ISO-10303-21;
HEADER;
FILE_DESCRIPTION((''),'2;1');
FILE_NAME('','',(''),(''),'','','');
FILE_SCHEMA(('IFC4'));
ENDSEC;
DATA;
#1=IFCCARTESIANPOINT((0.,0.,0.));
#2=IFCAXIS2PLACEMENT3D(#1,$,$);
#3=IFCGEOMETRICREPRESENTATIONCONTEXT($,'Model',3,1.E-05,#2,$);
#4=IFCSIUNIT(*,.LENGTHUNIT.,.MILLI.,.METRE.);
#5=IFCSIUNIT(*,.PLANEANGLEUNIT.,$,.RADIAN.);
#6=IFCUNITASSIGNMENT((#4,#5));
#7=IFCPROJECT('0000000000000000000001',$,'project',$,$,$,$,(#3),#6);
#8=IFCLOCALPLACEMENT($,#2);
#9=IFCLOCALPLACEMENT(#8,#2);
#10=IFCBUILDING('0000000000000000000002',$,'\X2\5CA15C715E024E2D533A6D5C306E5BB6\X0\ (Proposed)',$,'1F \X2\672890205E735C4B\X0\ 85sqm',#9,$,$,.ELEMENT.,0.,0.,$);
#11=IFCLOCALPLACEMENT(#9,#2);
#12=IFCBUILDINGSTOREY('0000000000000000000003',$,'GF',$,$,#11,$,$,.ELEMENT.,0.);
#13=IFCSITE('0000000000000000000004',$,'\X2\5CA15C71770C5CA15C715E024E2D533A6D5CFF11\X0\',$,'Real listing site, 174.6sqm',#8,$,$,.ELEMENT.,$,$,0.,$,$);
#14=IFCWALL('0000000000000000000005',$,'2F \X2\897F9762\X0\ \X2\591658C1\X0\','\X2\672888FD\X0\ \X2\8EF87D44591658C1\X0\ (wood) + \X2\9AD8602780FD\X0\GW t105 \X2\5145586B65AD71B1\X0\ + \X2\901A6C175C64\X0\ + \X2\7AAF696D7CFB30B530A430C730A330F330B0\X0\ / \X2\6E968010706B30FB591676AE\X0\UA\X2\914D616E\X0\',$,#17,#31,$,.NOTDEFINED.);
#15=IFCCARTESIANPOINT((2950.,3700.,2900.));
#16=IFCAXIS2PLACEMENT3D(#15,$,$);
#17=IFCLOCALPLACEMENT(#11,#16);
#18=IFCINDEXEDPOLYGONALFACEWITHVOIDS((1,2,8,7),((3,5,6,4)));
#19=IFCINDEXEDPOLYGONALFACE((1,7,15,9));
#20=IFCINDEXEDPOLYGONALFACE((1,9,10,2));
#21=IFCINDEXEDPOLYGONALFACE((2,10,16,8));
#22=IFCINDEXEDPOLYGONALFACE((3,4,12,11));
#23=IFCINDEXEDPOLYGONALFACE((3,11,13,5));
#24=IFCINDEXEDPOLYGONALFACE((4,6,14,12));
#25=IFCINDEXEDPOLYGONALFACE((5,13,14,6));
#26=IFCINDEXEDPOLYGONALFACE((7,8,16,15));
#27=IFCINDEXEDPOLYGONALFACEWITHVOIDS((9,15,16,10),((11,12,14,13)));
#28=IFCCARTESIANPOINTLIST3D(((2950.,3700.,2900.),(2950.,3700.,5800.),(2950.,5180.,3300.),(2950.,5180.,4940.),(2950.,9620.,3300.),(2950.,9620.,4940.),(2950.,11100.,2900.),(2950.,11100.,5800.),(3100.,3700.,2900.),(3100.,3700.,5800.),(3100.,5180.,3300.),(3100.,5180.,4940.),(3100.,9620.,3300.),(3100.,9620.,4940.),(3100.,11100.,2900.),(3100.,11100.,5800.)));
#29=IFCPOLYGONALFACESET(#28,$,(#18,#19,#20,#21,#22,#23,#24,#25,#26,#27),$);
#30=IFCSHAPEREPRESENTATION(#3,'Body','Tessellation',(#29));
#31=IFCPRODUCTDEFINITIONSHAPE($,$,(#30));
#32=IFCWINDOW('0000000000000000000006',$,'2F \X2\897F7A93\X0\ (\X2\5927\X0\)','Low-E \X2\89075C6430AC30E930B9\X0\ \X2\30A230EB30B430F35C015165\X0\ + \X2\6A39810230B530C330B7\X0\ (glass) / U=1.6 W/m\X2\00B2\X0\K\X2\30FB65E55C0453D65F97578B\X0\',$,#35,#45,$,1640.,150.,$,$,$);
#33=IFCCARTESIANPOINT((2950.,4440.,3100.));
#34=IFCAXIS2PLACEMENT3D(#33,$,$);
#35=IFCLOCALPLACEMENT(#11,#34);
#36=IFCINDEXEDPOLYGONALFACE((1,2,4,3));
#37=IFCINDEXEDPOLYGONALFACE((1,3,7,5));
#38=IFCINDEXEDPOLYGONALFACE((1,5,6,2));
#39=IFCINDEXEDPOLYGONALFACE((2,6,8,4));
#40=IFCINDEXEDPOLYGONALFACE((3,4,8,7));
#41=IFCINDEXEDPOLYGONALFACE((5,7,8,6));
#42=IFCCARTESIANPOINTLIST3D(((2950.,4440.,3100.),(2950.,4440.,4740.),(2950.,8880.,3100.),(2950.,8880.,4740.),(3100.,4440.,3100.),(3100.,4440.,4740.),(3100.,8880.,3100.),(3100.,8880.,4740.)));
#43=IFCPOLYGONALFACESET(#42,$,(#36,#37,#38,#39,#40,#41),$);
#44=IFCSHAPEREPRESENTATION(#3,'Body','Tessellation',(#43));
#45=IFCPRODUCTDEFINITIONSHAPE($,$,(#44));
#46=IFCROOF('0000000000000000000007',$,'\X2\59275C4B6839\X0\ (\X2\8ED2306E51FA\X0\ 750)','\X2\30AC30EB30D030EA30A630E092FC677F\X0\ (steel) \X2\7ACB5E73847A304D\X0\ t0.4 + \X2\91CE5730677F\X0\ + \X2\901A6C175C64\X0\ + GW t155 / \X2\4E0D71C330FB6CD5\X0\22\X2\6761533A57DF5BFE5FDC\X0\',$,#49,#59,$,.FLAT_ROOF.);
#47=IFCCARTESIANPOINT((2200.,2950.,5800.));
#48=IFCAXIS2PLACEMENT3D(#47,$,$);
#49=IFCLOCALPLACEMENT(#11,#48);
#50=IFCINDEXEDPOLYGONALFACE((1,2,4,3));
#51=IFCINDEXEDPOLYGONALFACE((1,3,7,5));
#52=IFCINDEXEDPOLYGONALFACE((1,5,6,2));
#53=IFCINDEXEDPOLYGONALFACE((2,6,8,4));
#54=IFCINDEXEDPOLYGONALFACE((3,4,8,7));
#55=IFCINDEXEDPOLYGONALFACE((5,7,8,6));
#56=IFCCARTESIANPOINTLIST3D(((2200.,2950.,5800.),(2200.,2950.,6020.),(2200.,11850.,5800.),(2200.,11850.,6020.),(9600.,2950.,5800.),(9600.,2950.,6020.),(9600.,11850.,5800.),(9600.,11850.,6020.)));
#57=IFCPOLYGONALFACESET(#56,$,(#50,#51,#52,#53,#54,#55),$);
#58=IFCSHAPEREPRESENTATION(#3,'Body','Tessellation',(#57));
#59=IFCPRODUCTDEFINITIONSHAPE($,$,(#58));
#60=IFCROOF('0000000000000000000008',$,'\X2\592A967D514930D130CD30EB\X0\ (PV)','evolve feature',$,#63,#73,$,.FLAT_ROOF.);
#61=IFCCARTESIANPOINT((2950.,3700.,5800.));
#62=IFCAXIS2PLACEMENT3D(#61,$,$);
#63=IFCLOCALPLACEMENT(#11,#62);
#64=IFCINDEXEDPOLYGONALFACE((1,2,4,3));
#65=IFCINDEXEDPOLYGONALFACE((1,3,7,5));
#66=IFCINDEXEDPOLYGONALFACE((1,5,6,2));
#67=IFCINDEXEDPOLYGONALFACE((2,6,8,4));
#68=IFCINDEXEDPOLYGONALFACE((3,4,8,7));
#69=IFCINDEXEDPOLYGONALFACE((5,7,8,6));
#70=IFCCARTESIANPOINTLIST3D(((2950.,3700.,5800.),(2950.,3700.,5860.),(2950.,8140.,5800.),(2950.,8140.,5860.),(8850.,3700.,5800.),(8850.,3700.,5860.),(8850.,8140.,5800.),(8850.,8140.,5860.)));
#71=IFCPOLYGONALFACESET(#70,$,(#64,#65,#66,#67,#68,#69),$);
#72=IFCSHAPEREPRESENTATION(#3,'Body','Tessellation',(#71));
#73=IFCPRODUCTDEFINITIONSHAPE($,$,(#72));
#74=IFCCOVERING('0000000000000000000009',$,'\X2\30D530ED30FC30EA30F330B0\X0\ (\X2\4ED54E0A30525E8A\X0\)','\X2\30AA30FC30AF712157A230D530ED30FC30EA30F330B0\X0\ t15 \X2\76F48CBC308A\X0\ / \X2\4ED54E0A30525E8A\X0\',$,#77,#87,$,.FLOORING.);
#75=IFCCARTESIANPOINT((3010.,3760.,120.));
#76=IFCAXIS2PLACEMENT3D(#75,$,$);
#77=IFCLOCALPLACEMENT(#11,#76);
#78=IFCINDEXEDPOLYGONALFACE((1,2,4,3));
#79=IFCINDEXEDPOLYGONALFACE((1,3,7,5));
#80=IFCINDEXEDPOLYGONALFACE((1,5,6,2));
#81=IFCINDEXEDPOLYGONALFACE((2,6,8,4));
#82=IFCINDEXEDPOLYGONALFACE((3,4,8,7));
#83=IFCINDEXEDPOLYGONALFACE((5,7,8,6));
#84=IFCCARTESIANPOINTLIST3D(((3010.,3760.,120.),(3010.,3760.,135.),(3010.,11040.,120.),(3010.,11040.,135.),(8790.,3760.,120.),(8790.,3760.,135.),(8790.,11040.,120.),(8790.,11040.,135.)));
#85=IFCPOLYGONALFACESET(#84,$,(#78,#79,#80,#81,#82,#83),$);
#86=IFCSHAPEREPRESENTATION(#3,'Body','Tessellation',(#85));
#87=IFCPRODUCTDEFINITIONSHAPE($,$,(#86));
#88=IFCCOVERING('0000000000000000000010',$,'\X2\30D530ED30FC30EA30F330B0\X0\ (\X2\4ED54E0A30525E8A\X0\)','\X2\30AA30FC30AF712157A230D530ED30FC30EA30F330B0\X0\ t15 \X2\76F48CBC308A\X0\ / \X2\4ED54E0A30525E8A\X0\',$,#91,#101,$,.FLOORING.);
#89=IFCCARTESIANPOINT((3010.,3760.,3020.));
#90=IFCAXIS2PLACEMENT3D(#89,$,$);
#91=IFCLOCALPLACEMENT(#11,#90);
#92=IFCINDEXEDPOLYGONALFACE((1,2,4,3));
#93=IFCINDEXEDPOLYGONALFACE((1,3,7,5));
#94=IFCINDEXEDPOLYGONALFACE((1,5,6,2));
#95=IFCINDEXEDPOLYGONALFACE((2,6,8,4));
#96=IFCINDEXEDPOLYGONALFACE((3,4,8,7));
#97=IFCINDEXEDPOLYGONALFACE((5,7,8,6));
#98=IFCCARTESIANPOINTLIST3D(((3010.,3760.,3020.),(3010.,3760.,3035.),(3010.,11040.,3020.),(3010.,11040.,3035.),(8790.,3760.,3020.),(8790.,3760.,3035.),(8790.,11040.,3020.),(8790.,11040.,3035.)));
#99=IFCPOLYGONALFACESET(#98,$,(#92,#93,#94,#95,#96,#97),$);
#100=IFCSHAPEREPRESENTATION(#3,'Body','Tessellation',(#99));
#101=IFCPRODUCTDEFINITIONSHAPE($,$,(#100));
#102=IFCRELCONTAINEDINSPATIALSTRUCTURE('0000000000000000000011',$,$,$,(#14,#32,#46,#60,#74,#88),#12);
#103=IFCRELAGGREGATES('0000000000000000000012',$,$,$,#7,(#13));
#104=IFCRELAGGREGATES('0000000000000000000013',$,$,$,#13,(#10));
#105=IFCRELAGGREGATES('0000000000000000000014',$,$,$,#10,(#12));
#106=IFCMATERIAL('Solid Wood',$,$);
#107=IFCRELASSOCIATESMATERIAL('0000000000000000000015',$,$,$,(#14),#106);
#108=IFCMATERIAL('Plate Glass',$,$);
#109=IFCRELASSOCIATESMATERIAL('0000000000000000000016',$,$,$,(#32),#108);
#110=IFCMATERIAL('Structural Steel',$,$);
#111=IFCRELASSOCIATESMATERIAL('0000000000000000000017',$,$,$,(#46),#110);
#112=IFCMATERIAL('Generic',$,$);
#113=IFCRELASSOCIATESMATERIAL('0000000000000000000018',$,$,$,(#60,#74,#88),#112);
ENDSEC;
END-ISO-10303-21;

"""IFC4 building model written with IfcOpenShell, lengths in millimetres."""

from ifc_helpers import new_model, si_unit, frame, frame_2d, origin, place, context, project, spatial, rectangle, extrude, material, element, fill, save


model = new_model("IFC4")

# Units and contexts
model_context = context("Model", 3, precision=1e-05, world=origin())
ifc_project = project(units=[si_unit("LENGTHUNIT", "METRE", prefix="MILLI"), si_unit("PLANEANGLEUNIT", "RADIAN")], contexts=[model_context])

# Site, building, storey
site_placement = place(None, origin())
site = spatial("IfcSite", under=ifc_project, at=site_placement, Name="岡山県岡山市中区浜１", ObjectType="Real listing site, 174.6sqm", CompositionType="ELEMENT", RefElevation=0.0)
building_placement = place(site_placement, origin())
building = spatial("IfcBuilding", under=site, at=building_placement, Name="岡山市中区浜の家 (Proposed)", ObjectType="1F 木造平屋 85sqm", CompositionType="ELEMENT", ElevationOfRefHeight=0.0, ElevationOfTerrain=0.0)
storey_placement = place(building_placement, origin())
storey = spatial("IfcBuildingStorey", under=building, at=storey_placement, Name="GF", CompositionType="ELEMENT", Elevation=0.0)

# Shared definitions
ifc_material_1 = material(Name="Solid Wood")
ifc_material_2 = material(Name="Generic")

# Shared definitions
ifc_material_3 = material(Name="Plate Glass")

# Wall, opening, window
wall_1_placement = place(storey_placement, frame((2950.0, 3700.0, 2900.0)))
wall_1 = element("IfcWall", 1, at=wall_1_placement, inside=storey, material=ifc_material_1, Name="2F 西面 外壁", Description="木製 軸組外壁 (wood) + 高性能GW t105 充填断熱 + 通気層 + 窯業系サイディング / 準耐火・外皮UA配慮", PredefinedType="NOTDEFINED", context=model_context, shape_type="SweptSolid", body=[
    extrude(rectangle(XDim=150.0, YDim=7400.0, at=frame_2d((75.0, 3700.0))), frame((2950.0, 3700.0, 2900.0)), (0.0, 0.0, 1.0), 2900.0),
])
opening_1_placement = place(storey_placement, frame((2950.0, 4440.0, 3100.0)))
opening_1 = element("IfcOpeningElement", 2, at=opening_1_placement, cuts=wall_1, PredefinedType="NOTDEFINED", context=model_context, shape_type="SweptSolid", body=[
    extrude(rectangle(XDim=150.0, YDim=4440.0, at=frame_2d((75.0, 2220.0))), frame((2950.0, 4440.0, 3100.0)), (0.0, 0.0, 1.0), 1640.0),
])
window_1_placement = place(storey_placement, frame((2950.0, 4440.0, 3100.0)))
window_1 = element("IfcWindow", 3, at=window_1_placement, inside=storey, material=ifc_material_3, Name="2F 西窓 (大)", Description="Low-E 複層ガラス アルゴン封入 + 樹脂サッシ (glass) / U=1.6 W/m²K・日射取得型", OverallHeight=1640.0, OverallWidth=150.0, context=model_context, shape_type="SweptSolid", body=[
    extrude(rectangle(XDim=150.0, YDim=4440.0, at=frame_2d((75.0, 2220.0))), frame((2950.0, 4440.0, 3100.0)), (0.0, 0.0, 1.0), 1640.0),
])
fill(opening_1, window_1)

# Roofs
ifc_material_4 = material(Name="Structural Steel")
roof_1_placement = place(storey_placement, frame((2200.0, 2950.0, 5800.0)))
element("IfcRoof", 4, at=roof_1_placement, inside=storey, material=ifc_material_4, Name="大屋根 (軒の出 750)", Description="ガルバリウム鋼板 (steel) 立平葺き t0.4 + 野地板 + 通気層 + GW t155 / 不燃・法22条区域対応", PredefinedType="FLAT_ROOF", context=model_context, shape_type="SweptSolid", body=[
    extrude(rectangle(XDim=7400.0, YDim=8900.0, at=frame_2d((3700.0, 4450.0))), frame((2200.0, 2950.0, 5800.0)), (0.0, 0.0, 1.0), 220.0),
])
roof_2_placement = place(storey_placement, frame((2950.0, 3700.0, 5800.0)))
element("IfcRoof", 5, at=roof_2_placement, inside=storey, material=ifc_material_2, Name="太陽光パネル (PV)", Description="evolve feature", PredefinedType="FLAT_ROOF", context=model_context, shape_type="SweptSolid", body=[
    extrude(rectangle(XDim=5900.0, YDim=4440.0, at=frame_2d((2950.0, 2220.0))), frame((2950.0, 3700.0, 5800.0)), (0.0, 0.0, 1.0), 60.0),
])

# Coverings
covering_1_placement = place(storey_placement, frame((3010.0, 3760.0, 120.0)))
element("IfcCovering", 6, at=covering_1_placement, inside=storey, material=ifc_material_2, Name="フローリング (仕上げ床)", Description="オーク無垢フローリング t15 直貼り / 仕上げ床", PredefinedType="FLOORING", context=model_context, shape_type="SweptSolid", body=[
    extrude(rectangle(XDim=5780.0, YDim=7280.0, at=frame_2d((2890.0, 3640.0))), frame((3010.0, 3760.0, 120.0)), (0.0, 0.0, 1.0), 15.0),
])
covering_2_placement = place(storey_placement, frame((3010.0, 3760.0, 3020.0)))
element("IfcCovering", 7, at=covering_2_placement, inside=storey, material=ifc_material_2, Name="フローリング (仕上げ床)", Description="オーク無垢フローリング t15 直貼り / 仕上げ床", PredefinedType="FLOORING", context=model_context, shape_type="SweptSolid", body=[
    extrude(rectangle(XDim=5780.0, YDim=7280.0, at=frame_2d((2890.0, 3640.0))), frame((3010.0, 3760.0, 3020.0)), (0.0, 0.0, 1.0), 15.0),
])

save(model, "model.ifc")
